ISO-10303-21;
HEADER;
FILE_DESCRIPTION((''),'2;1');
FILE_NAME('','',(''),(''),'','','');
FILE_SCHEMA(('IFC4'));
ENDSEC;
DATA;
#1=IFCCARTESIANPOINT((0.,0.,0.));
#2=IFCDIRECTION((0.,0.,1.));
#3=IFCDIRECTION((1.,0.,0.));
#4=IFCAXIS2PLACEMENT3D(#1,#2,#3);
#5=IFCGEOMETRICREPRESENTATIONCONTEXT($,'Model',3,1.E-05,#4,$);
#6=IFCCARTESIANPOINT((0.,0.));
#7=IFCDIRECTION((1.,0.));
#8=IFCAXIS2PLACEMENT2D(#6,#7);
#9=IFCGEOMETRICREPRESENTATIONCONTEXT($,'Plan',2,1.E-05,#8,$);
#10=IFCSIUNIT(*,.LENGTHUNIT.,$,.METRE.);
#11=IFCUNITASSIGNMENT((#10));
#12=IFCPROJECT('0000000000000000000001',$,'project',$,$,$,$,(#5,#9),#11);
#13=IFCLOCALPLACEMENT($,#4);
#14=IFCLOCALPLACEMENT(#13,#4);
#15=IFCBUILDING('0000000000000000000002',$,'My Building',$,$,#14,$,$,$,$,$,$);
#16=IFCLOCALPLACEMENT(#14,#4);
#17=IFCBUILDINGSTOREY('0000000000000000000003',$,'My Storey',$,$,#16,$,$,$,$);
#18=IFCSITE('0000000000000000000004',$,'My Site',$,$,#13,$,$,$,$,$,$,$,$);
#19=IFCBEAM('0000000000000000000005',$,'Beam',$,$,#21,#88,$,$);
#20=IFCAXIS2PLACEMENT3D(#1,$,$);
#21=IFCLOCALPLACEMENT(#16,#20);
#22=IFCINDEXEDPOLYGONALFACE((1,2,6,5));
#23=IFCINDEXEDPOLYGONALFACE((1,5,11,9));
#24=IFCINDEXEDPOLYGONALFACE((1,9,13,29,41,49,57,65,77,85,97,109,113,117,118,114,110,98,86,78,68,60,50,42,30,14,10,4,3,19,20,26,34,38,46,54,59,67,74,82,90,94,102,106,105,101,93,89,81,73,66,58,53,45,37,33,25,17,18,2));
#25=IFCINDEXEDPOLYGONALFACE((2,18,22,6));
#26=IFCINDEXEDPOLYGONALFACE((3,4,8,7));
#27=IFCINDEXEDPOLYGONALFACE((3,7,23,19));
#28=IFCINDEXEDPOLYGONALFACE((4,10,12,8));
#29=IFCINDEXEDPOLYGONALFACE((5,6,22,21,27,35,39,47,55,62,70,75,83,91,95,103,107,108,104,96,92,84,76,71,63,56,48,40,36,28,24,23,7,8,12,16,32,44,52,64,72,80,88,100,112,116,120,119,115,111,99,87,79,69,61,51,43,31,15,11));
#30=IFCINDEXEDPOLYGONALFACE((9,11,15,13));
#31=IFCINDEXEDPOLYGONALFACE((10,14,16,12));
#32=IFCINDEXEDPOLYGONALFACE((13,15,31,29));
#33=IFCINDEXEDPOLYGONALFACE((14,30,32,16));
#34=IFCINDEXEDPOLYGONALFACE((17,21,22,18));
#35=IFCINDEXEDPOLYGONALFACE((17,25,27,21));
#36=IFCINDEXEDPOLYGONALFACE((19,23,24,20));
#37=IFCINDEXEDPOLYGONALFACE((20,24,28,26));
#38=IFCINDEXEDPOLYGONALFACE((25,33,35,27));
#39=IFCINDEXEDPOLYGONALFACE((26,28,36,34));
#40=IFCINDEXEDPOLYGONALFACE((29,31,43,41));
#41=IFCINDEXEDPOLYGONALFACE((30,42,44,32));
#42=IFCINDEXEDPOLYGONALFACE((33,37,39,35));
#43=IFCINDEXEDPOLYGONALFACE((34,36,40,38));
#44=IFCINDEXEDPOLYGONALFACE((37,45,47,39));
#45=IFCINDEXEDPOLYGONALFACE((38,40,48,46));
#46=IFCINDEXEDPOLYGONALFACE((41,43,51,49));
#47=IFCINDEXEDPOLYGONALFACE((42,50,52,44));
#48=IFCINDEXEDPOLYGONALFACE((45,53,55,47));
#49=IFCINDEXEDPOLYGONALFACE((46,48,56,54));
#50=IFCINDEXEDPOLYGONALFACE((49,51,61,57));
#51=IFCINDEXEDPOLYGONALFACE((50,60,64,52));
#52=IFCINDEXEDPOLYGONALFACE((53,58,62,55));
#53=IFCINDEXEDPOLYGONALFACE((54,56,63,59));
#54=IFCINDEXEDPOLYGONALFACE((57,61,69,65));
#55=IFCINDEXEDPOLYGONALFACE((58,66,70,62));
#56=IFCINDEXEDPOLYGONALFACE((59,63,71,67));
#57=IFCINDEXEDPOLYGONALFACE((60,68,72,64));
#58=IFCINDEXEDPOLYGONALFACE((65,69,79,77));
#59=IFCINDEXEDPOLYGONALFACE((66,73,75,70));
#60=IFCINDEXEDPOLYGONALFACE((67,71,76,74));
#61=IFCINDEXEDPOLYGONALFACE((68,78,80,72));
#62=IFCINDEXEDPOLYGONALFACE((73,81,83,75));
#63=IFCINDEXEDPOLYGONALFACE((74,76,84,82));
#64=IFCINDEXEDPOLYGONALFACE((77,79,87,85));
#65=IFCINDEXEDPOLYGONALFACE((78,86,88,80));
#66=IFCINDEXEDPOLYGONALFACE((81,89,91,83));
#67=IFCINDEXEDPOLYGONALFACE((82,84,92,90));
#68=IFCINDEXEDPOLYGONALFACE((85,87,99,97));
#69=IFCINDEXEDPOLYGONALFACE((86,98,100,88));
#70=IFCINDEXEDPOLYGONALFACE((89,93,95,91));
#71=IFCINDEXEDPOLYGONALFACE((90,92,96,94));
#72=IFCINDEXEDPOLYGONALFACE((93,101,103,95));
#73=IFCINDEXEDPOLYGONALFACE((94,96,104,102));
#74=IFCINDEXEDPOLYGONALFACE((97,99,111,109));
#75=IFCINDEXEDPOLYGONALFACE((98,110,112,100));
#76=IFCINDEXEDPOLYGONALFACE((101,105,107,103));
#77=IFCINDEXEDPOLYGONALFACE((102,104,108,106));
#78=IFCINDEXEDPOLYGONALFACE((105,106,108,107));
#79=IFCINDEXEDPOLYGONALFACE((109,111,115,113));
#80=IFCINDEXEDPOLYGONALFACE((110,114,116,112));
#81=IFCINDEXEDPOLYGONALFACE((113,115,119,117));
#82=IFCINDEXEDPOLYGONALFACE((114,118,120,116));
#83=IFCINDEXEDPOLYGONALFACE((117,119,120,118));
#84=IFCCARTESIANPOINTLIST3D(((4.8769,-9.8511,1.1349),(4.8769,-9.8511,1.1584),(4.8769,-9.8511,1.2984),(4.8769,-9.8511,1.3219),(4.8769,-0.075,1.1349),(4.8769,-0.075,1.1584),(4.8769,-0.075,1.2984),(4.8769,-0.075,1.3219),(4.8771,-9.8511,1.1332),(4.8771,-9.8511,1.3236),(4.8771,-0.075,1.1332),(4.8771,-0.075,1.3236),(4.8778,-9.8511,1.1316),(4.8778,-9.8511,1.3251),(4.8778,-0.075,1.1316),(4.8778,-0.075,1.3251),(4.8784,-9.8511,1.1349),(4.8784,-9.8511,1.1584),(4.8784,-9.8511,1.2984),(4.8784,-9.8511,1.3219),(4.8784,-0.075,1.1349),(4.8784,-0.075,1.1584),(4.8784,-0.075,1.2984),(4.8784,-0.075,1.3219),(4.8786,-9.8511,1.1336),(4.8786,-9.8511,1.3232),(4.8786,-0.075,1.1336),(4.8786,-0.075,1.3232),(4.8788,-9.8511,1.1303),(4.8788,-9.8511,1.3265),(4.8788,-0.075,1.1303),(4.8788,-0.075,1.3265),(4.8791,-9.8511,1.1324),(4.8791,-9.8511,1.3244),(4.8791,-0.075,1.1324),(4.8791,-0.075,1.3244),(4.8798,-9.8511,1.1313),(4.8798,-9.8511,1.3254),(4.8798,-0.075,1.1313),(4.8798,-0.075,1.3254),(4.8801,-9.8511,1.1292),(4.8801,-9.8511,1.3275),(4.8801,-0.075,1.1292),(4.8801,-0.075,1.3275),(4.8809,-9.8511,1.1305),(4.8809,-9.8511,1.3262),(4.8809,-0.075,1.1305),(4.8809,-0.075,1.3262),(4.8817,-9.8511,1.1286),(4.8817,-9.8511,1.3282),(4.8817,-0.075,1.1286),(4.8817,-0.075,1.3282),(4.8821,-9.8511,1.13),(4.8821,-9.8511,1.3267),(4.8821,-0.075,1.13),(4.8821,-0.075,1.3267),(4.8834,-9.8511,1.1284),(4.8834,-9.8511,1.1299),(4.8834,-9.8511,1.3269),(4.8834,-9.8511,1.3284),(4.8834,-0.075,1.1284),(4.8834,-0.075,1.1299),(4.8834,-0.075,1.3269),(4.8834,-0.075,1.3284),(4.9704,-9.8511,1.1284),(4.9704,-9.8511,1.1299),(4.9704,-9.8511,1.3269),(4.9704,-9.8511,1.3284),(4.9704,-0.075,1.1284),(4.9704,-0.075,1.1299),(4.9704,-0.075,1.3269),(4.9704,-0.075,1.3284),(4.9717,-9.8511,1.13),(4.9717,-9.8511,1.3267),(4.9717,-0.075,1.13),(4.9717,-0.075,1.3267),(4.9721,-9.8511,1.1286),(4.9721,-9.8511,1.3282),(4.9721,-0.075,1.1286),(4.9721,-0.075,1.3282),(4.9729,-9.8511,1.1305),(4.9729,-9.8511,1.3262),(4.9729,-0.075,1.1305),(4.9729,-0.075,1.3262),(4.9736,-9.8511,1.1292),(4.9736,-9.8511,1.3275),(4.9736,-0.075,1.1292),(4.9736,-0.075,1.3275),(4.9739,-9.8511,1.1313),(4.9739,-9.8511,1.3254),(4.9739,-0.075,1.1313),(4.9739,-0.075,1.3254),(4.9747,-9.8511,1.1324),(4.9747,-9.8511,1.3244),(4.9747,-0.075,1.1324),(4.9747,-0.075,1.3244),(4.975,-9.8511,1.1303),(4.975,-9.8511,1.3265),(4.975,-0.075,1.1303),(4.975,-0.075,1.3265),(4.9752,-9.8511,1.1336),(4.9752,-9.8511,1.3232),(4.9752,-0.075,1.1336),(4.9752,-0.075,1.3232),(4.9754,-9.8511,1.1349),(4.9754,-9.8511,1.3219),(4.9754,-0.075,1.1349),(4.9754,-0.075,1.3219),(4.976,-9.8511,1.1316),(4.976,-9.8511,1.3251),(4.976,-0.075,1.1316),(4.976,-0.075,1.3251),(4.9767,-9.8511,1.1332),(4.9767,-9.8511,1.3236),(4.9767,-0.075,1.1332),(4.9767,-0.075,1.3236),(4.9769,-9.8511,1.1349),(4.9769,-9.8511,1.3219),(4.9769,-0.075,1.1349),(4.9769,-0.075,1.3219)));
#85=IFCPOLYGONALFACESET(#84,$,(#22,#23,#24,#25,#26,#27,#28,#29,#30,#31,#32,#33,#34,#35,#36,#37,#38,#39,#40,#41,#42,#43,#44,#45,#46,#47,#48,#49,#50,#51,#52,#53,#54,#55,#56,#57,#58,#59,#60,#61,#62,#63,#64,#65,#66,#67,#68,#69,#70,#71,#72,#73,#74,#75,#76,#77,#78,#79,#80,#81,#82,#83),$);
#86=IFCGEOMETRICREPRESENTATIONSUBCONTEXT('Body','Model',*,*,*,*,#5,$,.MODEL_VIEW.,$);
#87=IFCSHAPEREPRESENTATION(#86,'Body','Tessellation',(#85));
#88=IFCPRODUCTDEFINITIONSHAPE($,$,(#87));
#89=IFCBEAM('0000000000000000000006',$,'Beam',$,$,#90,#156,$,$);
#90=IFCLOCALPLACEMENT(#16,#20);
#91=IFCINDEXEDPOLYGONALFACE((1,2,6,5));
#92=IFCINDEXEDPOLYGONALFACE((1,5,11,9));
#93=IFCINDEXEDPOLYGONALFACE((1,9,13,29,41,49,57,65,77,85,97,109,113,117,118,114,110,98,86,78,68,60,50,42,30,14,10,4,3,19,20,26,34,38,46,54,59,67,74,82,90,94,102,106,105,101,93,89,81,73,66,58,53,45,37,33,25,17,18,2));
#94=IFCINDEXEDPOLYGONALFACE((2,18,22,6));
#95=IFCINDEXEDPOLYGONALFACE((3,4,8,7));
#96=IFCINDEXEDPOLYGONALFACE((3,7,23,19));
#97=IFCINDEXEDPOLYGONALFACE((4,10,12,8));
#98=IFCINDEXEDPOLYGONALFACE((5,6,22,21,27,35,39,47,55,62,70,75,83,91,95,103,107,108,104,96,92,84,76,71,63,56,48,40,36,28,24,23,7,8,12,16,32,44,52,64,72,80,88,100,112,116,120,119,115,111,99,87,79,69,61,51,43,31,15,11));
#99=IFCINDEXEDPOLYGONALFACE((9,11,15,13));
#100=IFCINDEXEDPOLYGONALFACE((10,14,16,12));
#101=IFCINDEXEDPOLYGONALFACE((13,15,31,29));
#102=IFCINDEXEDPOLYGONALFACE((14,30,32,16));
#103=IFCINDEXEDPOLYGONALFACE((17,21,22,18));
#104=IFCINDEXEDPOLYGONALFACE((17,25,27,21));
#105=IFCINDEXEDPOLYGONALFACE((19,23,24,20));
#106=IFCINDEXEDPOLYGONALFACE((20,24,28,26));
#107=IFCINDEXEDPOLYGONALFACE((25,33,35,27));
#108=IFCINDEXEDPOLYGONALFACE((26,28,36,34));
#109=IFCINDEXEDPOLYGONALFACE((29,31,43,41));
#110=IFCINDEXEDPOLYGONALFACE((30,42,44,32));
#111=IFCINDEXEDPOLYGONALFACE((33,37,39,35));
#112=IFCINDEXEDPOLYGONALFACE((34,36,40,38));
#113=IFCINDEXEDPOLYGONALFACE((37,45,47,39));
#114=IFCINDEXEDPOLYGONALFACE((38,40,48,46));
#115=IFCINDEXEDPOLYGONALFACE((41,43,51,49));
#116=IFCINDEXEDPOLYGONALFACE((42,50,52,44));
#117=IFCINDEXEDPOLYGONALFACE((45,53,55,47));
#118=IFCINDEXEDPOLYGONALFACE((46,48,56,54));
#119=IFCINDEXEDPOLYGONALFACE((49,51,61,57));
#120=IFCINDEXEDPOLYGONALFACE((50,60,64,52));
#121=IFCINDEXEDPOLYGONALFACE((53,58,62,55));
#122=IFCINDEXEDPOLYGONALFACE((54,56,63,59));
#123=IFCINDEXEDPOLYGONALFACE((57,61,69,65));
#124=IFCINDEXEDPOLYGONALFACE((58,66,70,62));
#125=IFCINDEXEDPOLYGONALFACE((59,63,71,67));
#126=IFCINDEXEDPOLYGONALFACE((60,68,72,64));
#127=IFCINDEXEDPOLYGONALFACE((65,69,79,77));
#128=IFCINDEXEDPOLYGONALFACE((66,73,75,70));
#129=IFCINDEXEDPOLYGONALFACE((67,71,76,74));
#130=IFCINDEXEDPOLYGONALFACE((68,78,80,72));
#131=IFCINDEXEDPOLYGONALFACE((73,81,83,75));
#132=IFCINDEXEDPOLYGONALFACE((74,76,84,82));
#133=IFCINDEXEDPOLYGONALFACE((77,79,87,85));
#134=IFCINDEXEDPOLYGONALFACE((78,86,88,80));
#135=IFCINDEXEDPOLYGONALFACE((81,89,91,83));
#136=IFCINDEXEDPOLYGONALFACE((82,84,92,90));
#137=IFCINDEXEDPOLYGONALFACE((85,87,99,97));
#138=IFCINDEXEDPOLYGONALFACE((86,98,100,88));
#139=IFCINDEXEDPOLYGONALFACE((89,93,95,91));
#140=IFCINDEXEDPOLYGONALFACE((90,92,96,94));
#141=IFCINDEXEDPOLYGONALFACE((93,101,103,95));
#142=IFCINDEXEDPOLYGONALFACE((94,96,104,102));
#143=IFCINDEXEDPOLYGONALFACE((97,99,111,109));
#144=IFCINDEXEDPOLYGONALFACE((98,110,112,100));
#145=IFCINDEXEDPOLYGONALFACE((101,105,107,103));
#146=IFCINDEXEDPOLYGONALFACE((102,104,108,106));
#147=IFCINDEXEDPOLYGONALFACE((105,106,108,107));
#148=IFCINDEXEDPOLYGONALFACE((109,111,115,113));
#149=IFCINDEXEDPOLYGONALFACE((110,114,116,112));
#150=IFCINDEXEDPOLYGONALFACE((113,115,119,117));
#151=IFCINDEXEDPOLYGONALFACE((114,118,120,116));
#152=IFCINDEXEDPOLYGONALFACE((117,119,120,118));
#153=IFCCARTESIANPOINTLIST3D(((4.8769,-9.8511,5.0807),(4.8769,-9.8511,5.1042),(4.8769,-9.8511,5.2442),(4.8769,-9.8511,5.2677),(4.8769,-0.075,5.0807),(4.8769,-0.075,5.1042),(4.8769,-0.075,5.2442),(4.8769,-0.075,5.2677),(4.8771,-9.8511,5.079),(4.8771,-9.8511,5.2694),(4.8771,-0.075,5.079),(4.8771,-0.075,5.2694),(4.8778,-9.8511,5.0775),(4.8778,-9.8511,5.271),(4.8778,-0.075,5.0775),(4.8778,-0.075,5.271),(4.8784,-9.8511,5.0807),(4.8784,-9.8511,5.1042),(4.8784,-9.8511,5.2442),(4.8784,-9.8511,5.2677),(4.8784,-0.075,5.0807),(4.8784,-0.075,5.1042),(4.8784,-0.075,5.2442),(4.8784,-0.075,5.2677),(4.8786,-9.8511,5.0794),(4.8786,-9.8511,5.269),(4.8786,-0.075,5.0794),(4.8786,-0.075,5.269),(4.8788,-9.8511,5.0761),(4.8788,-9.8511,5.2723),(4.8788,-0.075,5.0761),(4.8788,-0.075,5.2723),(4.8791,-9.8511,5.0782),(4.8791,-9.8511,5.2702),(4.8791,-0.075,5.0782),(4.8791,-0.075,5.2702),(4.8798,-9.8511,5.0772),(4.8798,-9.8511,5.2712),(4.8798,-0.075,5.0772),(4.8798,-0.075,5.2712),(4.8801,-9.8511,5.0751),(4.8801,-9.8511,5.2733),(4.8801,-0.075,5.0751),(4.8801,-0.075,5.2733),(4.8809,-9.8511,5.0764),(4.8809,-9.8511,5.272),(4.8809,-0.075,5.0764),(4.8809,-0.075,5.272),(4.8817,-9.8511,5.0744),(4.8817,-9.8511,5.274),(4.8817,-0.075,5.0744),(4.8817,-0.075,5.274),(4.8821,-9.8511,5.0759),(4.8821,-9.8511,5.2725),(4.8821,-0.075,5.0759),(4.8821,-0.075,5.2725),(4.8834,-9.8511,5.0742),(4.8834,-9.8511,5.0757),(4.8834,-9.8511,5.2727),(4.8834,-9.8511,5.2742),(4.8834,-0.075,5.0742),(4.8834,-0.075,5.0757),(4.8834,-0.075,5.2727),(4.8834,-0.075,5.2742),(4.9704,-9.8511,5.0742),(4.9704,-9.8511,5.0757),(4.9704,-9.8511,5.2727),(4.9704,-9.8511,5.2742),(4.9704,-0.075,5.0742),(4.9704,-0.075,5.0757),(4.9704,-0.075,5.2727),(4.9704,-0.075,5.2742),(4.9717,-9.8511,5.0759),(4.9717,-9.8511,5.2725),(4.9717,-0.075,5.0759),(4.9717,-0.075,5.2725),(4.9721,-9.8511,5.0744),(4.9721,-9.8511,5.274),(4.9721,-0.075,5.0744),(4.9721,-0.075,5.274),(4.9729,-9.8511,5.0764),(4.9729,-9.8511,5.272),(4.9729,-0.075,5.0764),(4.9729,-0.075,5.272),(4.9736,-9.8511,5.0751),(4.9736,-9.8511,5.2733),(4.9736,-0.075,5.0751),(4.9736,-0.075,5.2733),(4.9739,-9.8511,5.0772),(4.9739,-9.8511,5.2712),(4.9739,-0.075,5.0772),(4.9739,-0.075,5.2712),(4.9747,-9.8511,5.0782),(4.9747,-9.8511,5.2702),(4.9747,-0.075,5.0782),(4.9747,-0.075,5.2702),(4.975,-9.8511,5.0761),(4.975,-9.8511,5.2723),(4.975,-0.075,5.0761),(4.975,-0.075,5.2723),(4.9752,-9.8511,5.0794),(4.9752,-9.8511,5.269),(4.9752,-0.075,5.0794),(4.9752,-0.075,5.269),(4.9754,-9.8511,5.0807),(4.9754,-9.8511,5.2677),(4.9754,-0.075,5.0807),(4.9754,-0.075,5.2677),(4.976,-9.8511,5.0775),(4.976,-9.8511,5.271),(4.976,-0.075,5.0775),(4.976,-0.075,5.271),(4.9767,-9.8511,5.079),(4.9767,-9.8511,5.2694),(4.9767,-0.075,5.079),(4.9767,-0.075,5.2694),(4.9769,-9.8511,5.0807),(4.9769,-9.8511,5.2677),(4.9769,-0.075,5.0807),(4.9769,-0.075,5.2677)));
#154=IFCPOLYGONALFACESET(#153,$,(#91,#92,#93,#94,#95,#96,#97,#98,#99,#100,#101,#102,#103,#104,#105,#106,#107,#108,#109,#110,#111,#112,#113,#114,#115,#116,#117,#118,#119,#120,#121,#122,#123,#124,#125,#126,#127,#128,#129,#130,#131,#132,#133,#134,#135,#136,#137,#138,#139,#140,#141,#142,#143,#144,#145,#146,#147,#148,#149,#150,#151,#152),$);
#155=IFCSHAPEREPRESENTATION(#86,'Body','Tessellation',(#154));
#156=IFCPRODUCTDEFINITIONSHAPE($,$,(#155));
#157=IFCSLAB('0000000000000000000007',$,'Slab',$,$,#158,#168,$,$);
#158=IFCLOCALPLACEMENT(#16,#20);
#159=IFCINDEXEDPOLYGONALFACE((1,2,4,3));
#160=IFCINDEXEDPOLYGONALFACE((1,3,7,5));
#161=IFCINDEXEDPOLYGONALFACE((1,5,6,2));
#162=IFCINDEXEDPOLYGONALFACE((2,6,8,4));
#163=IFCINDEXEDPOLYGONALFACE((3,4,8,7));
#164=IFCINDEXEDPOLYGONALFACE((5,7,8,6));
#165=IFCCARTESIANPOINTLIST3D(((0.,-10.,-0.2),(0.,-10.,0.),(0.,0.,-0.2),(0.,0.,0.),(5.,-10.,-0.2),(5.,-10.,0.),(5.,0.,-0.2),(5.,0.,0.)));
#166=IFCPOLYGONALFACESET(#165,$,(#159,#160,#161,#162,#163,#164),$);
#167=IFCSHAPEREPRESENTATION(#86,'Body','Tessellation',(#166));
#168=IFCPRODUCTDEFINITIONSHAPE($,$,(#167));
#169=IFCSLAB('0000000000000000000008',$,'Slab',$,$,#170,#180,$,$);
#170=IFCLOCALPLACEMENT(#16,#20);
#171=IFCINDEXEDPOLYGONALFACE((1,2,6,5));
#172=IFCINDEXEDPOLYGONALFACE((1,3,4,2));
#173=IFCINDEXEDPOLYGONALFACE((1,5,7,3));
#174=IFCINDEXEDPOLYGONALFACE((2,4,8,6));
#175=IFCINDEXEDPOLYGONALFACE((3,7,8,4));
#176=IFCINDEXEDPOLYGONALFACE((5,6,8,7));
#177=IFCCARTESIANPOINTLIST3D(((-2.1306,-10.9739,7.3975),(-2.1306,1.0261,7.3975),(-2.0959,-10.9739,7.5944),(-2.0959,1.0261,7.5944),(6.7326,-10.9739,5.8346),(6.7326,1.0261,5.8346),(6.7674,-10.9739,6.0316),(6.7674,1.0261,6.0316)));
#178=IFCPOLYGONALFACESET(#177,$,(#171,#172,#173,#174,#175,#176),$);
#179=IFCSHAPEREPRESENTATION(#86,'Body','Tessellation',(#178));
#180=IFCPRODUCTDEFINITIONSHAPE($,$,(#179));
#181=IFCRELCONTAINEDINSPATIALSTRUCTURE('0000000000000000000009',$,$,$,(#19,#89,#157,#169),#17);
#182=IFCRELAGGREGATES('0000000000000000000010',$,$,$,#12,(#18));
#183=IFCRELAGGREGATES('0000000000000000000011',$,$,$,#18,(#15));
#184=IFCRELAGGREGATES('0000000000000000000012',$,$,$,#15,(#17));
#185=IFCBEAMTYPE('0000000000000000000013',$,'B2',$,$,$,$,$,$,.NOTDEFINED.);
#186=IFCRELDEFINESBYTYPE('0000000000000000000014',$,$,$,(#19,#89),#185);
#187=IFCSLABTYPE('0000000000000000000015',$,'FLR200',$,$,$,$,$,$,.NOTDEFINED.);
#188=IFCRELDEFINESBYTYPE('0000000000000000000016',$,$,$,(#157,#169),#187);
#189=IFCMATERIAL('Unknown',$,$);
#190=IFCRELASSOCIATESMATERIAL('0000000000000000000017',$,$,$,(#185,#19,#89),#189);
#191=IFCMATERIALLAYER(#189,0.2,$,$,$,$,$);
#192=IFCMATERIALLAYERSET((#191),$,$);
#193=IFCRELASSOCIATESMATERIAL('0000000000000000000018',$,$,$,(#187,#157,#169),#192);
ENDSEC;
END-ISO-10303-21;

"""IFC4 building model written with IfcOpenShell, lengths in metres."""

from ifc_helpers import new_model, si_unit, frame, origin_with_axes, origin_2d_with_axis, place, context, subcontext, project, spatial, indexed_curve, c_section, outline, extrude, material, layer, layer_set, layer_usage, material_profile, profile_set, profile_usage, type_object, element, save


model = new_model("IFC4")

# Units and contexts
model_context = context("Model", 3, precision=1e-05, world=origin_with_axes())
plan_context = context("Plan", 2, precision=1e-05, world=origin_2d_with_axis())
body_context = subcontext(model_context, "Body", "Model", "MODEL_VIEW")
ifc_project = project(units=[si_unit("LENGTHUNIT", "METRE")], contexts=[model_context, plan_context])

# Site, building, storey
site_placement = place(None, origin_with_axes())
site = spatial("IfcSite", under=ifc_project, at=site_placement, Name="My Site")
building_placement = place(site_placement, origin_with_axes())
building = spatial("IfcBuilding", under=site, at=building_placement, Name="My Building")
storey_placement = place(building_placement, origin_with_axes())
storey = spatial("IfcBuildingStorey", under=building, at=storey_placement, Name="My Storey")

# Shared definitions
ifc_material = material(Name="Unknown")

# Beams
ifc_material_profile_1 = material_profile(ifc_material, c_section(Depth=0.2, Width=0.1, WallThickness=0.0015, Girth=0.03, InternalFilletRadius=0.005))
ifc_profile_set_1 = profile_set([ifc_material_profile_1])
beam_type = type_object("IfcBeamType", Name="B2", PredefinedType="NOTDEFINED", material=ifc_profile_set_1)
ifc_profile_usage_1 = profile_usage(ifc_profile_set_1, cardinal=5)
beam_1_placement = place(storey_placement, frame((4.9269, -9.8511, 1.2284), z_axis=(0.0, 1.0, 0.0), x_axis=(-1.0, 0.0, 0.0)))
element("IfcBeam", 1, at=beam_1_placement, inside=storey, type_object=beam_type, material=ifc_profile_usage_1, Name="Beam", context=body_context, shape_type="SweptSolid", body=[
    extrude(c_section(Depth=0.2, Width=0.1, WallThickness=0.0015, Girth=0.03, InternalFilletRadius=0.005), origin_with_axes(), (0.0, 0.0, 1.0), 9.7761),
])
ifc_profile_usage_2 = profile_usage(ifc_profile_set_1, cardinal=5)
beam_2_placement = place(storey_placement, frame((4.9269, -9.8511, 5.1742), z_axis=(0.0, 1.0, 0.0), x_axis=(-1.0, 0.0, 0.0)))
element("IfcBeam", 2, at=beam_2_placement, inside=storey, type_object=beam_type, material=ifc_profile_usage_2, Name="Beam", context=body_context, shape_type="SweptSolid", body=[
    extrude(c_section(Depth=0.2, Width=0.1, WallThickness=0.0015, Girth=0.03, InternalFilletRadius=0.005), origin_with_axes(), (0.0, 0.0, 1.0), 9.7761),
])

# Slabs
ifc_layer = layer(ifc_material, 0.2)
ifc_layer_set = layer_set([ifc_layer])
ifc_layer_usage_1 = layer_usage(ifc_layer_set, "AXIS3", "POSITIVE", -0.2)
slab_type = type_object("IfcSlabType", Name="FLR200", PredefinedType="NOTDEFINED", material=ifc_layer_set)
slab_1_placement = place(storey_placement, frame((0.0, -10.0, 0.0), z_axis=(0.0, 0.0, 1.0), x_axis=(1.0, 0.0, 0.0)))
element("IfcSlab", 3, at=slab_1_placement, inside=storey, type_object=slab_type, material=ifc_layer_usage_1, Name="Slab", context=body_context, shape_type="SweptSolid", body=[
    extrude(outline(indexed_curve([(0.0, 0.0), (5.0, 0.0), (5.0, 10.0), (0.0, 10.0), (0.0, 0.0)])), frame((0.0, 0.0, -0.2), z_axis=(0.0, 0.0, 1.0), x_axis=(1.0, 0.0, 0.0)), (0.0, 0.0, 1.0), 0.2),
])
ifc_layer_usage_2 = layer_usage(ifc_layer_set, "AXIS3", "POSITIVE", -0.2)
slab_2_placement = place(storey_placement, frame((-2.0959, 1.0261, 7.5944), z_axis=(0.173648, 0.0, 0.984808), x_axis=(0.984808, 0.0, -0.173648)))
element("IfcSlab", 4, at=slab_2_placement, inside=storey, type_object=slab_type, material=ifc_layer_usage_2, Name="Slab", context=body_context, shape_type="SweptSolid", body=[
    extrude(outline(indexed_curve([(0.0, 0.0), (0.0, -12.0), (9.0, -12.0), (9.0, 0.0), (0.0, 0.0)])), frame((0.0, 0.0, -0.2), z_axis=(0.0, 0.0, 1.0), x_axis=(1.0, 0.0, 0.0)), (0.0, 0.0, 1.0), 0.2),
])

save(model, "model.ifc")
